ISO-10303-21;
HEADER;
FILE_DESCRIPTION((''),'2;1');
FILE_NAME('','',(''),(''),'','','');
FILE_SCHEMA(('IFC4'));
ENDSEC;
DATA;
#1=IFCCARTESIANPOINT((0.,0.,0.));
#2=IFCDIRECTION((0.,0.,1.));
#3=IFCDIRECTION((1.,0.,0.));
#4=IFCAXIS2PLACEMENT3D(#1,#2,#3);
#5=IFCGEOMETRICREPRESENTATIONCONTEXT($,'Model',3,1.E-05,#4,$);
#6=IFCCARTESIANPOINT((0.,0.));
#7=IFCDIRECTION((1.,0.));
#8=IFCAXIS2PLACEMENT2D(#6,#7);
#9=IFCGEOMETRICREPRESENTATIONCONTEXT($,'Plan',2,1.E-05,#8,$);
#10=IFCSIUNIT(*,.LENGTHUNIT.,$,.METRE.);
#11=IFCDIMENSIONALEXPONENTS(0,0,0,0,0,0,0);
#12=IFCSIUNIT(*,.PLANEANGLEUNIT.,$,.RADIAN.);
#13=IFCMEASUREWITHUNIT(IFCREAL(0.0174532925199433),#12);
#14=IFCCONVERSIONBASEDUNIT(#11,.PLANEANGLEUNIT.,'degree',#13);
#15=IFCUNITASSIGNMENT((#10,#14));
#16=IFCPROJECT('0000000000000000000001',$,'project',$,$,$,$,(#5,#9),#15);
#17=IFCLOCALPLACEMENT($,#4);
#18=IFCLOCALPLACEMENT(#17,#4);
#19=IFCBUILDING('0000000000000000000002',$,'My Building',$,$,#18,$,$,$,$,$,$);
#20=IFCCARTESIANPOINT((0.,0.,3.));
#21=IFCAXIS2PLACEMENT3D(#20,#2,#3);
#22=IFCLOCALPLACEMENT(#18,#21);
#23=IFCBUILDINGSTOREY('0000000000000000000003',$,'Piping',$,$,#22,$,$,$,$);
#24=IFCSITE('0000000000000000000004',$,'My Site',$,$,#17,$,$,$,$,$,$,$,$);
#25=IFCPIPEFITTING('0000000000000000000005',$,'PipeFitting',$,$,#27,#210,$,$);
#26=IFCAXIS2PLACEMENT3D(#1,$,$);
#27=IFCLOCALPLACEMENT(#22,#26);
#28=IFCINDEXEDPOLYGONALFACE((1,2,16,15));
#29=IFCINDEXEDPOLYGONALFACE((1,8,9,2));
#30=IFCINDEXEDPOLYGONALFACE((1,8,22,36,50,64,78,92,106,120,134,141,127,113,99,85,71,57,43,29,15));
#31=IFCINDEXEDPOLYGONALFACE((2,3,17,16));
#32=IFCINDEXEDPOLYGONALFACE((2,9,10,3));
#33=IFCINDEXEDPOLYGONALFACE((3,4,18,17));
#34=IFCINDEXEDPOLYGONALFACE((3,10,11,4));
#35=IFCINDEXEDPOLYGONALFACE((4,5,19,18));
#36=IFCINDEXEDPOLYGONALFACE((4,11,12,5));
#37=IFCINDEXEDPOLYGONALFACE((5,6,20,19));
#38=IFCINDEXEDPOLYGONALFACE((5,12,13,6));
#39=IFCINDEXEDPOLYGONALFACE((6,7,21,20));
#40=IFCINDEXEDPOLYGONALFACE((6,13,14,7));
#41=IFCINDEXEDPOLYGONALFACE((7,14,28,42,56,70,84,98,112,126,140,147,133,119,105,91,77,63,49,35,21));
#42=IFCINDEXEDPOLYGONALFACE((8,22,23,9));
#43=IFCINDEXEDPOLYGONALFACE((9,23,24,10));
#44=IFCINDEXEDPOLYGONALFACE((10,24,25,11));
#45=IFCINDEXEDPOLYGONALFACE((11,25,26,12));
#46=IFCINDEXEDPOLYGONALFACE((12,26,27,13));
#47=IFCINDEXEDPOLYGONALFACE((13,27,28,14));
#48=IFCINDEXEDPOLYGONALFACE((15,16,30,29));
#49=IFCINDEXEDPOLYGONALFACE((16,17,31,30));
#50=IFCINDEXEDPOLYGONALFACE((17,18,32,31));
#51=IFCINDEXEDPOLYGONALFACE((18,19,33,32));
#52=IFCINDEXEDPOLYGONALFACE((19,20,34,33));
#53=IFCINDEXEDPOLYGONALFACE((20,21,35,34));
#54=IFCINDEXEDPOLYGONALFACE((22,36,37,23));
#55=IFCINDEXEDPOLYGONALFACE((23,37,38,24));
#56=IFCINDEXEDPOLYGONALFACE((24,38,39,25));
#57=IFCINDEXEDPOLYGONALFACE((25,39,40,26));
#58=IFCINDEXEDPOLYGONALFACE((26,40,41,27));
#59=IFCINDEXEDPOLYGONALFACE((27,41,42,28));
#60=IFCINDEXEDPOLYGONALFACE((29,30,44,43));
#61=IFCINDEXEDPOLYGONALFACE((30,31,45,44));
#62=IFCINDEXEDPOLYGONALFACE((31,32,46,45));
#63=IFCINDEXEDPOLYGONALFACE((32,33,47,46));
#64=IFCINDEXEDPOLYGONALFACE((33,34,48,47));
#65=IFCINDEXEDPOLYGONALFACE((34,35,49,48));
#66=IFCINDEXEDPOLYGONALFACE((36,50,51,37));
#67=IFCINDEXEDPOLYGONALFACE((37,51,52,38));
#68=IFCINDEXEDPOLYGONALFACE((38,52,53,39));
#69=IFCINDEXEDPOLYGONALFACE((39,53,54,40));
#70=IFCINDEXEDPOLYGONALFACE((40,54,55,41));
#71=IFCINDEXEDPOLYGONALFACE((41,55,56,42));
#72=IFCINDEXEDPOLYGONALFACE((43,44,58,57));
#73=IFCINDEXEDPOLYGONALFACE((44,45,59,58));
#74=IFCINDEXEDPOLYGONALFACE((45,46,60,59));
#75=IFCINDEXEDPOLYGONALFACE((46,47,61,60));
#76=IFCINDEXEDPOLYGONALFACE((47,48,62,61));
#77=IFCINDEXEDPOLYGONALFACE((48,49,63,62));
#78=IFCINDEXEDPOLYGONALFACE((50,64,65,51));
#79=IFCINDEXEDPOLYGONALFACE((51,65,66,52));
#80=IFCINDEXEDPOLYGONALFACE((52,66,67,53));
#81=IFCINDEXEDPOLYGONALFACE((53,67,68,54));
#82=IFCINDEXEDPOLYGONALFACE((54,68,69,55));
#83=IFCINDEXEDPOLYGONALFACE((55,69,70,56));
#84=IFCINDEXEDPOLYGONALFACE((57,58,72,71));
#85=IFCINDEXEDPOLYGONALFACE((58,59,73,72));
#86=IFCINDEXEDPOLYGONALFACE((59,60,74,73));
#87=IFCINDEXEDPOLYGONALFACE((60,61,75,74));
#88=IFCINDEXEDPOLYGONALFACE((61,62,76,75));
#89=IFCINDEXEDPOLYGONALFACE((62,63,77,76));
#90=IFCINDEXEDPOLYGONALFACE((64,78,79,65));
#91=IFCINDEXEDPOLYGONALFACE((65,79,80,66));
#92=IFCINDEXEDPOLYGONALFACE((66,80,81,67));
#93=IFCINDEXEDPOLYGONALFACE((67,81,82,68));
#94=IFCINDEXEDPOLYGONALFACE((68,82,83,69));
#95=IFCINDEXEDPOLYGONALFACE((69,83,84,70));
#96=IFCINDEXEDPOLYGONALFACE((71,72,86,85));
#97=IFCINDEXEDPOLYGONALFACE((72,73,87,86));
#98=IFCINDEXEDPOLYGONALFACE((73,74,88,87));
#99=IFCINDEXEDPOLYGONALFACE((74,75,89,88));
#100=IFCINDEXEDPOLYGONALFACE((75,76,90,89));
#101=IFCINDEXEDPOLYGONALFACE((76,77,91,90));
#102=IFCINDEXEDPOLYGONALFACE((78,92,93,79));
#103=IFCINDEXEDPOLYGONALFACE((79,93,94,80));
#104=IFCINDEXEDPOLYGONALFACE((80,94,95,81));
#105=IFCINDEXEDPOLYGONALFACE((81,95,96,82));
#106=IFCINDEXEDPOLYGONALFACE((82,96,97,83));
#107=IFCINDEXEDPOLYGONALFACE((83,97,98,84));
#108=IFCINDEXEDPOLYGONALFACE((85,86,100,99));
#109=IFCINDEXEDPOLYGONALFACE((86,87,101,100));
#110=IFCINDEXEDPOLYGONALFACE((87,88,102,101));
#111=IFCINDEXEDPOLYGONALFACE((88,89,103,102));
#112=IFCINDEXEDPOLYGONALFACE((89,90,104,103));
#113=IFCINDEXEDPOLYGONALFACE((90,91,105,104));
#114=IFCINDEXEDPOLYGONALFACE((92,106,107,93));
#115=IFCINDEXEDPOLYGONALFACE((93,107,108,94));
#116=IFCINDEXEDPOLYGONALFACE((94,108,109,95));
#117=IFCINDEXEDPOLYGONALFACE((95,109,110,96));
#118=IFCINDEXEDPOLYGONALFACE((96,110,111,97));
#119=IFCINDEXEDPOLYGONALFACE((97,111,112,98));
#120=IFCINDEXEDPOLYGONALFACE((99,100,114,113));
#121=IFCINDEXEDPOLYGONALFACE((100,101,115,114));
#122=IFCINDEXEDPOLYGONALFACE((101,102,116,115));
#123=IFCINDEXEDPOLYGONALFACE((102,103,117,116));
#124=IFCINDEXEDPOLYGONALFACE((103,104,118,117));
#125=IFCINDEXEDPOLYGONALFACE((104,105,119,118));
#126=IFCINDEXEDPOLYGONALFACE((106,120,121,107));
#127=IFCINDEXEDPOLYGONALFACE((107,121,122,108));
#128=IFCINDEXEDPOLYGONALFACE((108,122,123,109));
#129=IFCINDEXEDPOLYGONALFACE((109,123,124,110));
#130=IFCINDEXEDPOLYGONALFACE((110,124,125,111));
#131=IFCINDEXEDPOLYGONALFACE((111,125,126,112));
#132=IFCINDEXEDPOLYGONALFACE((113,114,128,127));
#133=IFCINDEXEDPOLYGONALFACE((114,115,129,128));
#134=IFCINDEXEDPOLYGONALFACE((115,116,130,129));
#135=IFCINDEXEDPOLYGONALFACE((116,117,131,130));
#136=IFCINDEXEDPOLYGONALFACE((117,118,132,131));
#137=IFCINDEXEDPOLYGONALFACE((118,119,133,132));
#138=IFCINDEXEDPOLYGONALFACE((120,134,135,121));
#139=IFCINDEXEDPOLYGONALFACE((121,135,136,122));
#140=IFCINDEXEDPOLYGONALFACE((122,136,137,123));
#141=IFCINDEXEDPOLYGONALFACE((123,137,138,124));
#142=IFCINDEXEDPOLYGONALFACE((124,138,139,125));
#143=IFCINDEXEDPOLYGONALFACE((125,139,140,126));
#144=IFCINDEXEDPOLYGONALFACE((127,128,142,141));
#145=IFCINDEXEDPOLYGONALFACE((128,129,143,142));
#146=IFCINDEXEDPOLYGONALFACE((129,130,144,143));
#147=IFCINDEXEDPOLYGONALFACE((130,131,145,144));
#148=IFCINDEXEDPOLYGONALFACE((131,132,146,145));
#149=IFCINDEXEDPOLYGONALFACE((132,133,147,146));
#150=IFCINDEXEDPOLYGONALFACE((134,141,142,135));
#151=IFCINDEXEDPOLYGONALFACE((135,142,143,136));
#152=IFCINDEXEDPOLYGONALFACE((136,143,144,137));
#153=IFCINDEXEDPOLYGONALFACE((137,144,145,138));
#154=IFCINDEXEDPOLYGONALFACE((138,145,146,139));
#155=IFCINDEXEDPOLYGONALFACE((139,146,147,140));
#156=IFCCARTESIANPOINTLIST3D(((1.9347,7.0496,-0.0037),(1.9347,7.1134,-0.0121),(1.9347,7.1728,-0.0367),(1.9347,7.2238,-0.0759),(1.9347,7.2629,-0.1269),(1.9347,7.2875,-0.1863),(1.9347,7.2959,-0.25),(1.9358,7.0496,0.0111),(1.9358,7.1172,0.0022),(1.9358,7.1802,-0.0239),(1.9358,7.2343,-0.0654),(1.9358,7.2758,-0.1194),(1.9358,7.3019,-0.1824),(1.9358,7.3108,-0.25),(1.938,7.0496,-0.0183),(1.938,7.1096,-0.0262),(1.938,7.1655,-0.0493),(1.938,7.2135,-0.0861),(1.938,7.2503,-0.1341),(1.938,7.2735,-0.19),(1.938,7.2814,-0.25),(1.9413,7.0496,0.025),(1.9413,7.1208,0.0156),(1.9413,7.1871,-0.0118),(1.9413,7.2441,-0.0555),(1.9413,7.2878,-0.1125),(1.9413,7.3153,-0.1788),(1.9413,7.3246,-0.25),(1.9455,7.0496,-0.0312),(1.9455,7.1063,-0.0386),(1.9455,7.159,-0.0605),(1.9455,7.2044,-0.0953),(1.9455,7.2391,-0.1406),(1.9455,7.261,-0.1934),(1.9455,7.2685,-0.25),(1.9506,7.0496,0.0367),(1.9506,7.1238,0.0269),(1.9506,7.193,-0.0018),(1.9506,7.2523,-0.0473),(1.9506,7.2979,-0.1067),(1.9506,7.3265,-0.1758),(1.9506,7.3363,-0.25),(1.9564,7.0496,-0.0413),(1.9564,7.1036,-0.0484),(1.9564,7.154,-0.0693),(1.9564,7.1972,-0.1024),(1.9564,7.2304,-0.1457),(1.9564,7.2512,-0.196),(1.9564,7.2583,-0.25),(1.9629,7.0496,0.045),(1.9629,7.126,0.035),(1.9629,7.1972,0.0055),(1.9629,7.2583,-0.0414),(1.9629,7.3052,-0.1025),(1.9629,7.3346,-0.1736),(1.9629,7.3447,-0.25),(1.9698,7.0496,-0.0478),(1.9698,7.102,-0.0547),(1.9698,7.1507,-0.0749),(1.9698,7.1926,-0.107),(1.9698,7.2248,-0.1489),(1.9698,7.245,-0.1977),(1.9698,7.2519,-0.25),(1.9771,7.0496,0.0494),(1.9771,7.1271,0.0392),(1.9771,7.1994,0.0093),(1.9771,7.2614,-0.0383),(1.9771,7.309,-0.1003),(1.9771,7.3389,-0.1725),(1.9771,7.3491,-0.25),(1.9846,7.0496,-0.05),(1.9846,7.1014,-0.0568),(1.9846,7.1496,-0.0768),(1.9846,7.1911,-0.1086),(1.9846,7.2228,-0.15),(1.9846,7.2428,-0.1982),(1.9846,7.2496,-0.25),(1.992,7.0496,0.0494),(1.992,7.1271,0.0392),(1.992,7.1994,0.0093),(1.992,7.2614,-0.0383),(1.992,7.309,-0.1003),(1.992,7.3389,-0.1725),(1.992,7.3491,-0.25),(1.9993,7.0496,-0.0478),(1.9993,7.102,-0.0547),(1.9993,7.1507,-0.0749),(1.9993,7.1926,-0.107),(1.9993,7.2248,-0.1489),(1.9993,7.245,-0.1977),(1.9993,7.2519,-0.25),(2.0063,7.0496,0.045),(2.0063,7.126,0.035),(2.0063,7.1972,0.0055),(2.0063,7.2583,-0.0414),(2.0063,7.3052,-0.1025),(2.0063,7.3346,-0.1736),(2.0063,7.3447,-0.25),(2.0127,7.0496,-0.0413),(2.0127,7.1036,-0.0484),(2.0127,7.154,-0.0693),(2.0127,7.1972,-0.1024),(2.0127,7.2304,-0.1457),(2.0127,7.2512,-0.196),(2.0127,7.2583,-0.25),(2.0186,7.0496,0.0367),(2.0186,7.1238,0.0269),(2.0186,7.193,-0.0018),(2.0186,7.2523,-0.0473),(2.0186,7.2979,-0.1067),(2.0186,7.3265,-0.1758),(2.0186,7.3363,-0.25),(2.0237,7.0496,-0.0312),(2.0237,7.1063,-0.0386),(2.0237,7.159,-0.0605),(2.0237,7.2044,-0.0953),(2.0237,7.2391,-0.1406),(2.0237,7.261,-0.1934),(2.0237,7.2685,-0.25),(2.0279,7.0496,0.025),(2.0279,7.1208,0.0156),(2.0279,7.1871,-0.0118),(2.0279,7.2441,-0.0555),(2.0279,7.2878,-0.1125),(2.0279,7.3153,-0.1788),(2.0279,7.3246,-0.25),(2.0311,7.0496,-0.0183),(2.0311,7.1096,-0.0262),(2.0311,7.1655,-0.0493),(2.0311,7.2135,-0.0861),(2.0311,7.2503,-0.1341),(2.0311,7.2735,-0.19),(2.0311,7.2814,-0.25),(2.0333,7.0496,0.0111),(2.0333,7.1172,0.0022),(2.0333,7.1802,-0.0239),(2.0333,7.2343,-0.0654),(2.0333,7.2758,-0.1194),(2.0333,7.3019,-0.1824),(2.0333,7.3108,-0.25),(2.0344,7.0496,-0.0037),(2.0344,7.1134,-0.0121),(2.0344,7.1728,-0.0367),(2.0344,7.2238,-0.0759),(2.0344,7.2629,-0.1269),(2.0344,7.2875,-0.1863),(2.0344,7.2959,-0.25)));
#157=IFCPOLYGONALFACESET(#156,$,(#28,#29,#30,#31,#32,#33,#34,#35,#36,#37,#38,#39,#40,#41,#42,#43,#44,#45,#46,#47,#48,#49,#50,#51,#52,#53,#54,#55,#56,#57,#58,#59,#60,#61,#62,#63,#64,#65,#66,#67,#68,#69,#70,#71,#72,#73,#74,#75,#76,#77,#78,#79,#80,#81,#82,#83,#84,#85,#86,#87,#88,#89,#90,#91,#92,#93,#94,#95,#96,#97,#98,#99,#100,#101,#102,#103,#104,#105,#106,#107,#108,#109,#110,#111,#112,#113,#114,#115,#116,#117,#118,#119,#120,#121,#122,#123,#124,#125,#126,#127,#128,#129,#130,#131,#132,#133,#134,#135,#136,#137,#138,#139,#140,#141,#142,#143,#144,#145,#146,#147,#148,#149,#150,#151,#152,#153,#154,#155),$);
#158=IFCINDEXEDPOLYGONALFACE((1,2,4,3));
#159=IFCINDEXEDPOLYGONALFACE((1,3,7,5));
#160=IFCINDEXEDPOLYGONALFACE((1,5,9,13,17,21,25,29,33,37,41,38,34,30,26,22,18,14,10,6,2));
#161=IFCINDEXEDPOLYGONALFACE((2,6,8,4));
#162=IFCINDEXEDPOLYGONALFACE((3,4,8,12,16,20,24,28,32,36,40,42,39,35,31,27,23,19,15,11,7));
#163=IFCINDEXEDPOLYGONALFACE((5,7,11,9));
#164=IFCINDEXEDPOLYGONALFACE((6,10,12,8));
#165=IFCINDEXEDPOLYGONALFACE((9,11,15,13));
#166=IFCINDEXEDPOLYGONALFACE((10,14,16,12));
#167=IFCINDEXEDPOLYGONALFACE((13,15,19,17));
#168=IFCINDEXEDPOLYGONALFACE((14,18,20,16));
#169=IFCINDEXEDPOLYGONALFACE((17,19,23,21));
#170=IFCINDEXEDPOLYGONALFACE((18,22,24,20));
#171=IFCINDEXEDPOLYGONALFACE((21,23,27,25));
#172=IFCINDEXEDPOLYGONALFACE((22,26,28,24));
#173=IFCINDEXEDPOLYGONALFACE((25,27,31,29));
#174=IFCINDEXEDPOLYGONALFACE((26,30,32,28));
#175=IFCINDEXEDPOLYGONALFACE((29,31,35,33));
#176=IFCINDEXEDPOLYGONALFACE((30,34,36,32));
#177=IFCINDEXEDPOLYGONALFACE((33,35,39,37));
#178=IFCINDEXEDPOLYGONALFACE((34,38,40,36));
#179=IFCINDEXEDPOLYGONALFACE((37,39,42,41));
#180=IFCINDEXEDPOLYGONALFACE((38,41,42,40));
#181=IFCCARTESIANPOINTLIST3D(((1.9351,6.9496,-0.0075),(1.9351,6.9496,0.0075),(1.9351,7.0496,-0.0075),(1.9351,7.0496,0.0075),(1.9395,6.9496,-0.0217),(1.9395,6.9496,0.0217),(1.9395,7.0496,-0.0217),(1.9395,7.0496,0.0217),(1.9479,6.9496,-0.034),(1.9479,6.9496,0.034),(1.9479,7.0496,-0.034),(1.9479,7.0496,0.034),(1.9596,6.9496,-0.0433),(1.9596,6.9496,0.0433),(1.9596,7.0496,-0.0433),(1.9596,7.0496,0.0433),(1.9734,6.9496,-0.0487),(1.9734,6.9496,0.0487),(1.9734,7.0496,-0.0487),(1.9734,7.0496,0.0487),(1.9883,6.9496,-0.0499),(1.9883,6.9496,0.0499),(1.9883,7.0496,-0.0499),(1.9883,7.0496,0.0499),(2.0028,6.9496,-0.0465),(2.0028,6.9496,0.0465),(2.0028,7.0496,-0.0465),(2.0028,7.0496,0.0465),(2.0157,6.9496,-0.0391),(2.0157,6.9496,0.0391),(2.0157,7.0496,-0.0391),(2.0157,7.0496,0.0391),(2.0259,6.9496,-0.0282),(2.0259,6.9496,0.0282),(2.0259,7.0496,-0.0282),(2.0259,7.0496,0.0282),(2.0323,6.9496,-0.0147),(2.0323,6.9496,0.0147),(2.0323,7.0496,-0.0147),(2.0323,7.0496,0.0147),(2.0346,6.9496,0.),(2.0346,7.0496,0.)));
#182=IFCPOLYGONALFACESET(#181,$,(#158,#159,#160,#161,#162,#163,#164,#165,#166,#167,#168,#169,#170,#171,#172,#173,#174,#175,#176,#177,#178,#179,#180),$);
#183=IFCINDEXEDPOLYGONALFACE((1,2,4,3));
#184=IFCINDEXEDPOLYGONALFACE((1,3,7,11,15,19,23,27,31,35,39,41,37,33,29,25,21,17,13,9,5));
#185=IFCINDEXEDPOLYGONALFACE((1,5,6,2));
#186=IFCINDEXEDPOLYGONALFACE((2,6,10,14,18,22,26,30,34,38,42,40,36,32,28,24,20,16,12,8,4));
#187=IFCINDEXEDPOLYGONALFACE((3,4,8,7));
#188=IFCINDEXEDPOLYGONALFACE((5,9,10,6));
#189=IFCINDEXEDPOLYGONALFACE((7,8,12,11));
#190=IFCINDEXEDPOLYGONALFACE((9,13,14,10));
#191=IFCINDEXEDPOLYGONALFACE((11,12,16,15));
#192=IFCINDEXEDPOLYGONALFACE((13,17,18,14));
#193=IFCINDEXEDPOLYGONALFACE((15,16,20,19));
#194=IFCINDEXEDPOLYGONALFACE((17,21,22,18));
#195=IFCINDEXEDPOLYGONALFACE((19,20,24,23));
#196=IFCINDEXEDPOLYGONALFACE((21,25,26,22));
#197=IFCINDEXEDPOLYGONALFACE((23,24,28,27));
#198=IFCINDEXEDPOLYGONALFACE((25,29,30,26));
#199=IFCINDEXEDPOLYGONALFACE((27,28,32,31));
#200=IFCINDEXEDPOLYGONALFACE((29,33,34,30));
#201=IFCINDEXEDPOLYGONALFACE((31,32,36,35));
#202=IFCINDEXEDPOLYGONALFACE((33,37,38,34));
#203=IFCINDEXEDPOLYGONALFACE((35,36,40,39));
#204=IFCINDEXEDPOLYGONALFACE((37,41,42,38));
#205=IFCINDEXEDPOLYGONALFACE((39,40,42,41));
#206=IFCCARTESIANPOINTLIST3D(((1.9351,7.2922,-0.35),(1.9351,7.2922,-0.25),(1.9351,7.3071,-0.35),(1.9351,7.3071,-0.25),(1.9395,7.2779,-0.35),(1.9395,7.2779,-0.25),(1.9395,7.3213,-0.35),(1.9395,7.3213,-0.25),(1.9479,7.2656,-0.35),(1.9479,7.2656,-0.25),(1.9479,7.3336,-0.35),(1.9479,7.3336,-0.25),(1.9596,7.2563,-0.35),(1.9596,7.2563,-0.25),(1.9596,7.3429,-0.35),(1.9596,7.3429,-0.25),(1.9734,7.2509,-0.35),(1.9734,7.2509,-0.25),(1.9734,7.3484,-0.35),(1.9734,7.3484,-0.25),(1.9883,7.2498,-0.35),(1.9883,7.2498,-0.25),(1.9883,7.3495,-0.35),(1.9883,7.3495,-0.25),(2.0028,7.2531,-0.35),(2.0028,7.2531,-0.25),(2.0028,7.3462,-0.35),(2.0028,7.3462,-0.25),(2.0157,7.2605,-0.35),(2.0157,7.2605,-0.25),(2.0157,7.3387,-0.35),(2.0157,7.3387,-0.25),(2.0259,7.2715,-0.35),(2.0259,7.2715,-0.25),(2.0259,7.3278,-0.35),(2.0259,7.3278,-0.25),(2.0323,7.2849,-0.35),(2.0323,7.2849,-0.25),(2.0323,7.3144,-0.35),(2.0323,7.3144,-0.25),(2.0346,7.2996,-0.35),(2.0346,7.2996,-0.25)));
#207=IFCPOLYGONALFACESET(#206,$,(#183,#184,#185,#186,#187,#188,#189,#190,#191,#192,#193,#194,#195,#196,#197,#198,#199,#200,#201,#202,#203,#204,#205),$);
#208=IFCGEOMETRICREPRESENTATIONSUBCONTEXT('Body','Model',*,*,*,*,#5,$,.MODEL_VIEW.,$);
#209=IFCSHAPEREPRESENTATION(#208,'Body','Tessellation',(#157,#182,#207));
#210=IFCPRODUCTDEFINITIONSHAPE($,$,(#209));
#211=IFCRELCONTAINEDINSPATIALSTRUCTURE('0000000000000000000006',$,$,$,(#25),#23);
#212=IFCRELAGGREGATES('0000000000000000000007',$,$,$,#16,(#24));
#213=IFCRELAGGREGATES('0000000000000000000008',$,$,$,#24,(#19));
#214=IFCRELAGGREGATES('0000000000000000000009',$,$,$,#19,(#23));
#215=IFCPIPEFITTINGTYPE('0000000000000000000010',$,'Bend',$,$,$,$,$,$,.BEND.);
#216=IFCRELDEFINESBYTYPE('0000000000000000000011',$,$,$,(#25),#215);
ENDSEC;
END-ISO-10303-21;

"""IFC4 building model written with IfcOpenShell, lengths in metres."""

from ifc_helpers import new_model, entity, si_unit, converted_unit, frame, origin_with_axes, origin_2d_with_axis, place, context, subcontext, project, spatial, circle, extrude, source, transform, mapped, type_object, type_shapes, element, save


model = new_model("IFC4")

# Units and contexts
model_context = context("Model", 3, precision=1e-05, world=origin_with_axes())
plan_context = context("Plan", 2, precision=1e-05, world=origin_2d_with_axis())
body_context = subcontext(model_context, "Body", "Model", "MODEL_VIEW")
ifc_project = project(units=[si_unit("LENGTHUNIT", "METRE"), converted_unit("PLANEANGLEUNIT", "degree", entity("IfcReal", 0.0174532925199433), si_unit("PLANEANGLEUNIT", "RADIAN"), dimensions=[0, 0, 0, 0, 0, 0, 0])], contexts=[model_context, plan_context])

# Site, building, storey
site_placement = place(None, origin_with_axes())
site = spatial("IfcSite", under=ifc_project, at=site_placement, Name="My Site")
building_placement = place(site_placement, origin_with_axes())
building = spatial("IfcBuilding", under=site, at=building_placement, Name="My Building")
storey_placement = place(building_placement, frame((0.0, 0.0, 3.0), z_axis=(0.0, 0.0, 1.0), x_axis=(1.0, 0.0, 0.0)))
storey = spatial("IfcBuildingStorey", under=building, at=storey_placement, Name="Piping")

# Pipe fitting
pipe_fitting_type = type_object("IfcPipeFittingType", Name="Bend", PredefinedType="BEND")
shared_shape = source(origin_with_axes(), body_context, "Body", "SolidModel", [
    entity("IfcSweptDiskSolid", entity("IfcIndexedPolyCurve", entity("IfcCartesianPointList3D", [[0.0, 0.0, -0.1], [0.0, -0.0732, -0.2768], [0.0, -0.25, -0.35]]), [entity("IfcArcIndex", [1, 2, 3])]), 0.05),
    extrude(circle(Radius=0.05), origin_with_axes(), (0.0, 0.0, -1.0), 0.1),
    extrude(circle(Radius=0.05), frame((0.0, -0.25, -0.35), z_axis=(0.0, -1.0, 0.0), x_axis=(1.0, 0.0, 0.0)), (0.0, 0.0, 1.0), 0.1),
])
type_shapes(pipe_fitting_type, [shared_shape])
for number, where, z_axis, x_axis, name in (
    (1, (1.9846, 6.9496, 0.0), (0.0, -1.0, 0.0), (1.0, 0.0, 0.0), "PipeFitting"),
):
    element("IfcPipeFitting", number, at=place(storey_placement, frame(where, z_axis=z_axis, x_axis=x_axis)), inside=storey, type_object=pipe_fitting_type, Name=name, context=body_context, shape_type="MappedRepresentation", body=[
        mapped(shared_shape, transform((0.0, 0.0, 0.0), x_axis=(1.0, 0.0, 0.0), y_axis=(0.0, 1.0, 0.0), z_axis=(0.0, 0.0, 1.0), scale=1.0)),
    ])

save(model, "model.ifc")
